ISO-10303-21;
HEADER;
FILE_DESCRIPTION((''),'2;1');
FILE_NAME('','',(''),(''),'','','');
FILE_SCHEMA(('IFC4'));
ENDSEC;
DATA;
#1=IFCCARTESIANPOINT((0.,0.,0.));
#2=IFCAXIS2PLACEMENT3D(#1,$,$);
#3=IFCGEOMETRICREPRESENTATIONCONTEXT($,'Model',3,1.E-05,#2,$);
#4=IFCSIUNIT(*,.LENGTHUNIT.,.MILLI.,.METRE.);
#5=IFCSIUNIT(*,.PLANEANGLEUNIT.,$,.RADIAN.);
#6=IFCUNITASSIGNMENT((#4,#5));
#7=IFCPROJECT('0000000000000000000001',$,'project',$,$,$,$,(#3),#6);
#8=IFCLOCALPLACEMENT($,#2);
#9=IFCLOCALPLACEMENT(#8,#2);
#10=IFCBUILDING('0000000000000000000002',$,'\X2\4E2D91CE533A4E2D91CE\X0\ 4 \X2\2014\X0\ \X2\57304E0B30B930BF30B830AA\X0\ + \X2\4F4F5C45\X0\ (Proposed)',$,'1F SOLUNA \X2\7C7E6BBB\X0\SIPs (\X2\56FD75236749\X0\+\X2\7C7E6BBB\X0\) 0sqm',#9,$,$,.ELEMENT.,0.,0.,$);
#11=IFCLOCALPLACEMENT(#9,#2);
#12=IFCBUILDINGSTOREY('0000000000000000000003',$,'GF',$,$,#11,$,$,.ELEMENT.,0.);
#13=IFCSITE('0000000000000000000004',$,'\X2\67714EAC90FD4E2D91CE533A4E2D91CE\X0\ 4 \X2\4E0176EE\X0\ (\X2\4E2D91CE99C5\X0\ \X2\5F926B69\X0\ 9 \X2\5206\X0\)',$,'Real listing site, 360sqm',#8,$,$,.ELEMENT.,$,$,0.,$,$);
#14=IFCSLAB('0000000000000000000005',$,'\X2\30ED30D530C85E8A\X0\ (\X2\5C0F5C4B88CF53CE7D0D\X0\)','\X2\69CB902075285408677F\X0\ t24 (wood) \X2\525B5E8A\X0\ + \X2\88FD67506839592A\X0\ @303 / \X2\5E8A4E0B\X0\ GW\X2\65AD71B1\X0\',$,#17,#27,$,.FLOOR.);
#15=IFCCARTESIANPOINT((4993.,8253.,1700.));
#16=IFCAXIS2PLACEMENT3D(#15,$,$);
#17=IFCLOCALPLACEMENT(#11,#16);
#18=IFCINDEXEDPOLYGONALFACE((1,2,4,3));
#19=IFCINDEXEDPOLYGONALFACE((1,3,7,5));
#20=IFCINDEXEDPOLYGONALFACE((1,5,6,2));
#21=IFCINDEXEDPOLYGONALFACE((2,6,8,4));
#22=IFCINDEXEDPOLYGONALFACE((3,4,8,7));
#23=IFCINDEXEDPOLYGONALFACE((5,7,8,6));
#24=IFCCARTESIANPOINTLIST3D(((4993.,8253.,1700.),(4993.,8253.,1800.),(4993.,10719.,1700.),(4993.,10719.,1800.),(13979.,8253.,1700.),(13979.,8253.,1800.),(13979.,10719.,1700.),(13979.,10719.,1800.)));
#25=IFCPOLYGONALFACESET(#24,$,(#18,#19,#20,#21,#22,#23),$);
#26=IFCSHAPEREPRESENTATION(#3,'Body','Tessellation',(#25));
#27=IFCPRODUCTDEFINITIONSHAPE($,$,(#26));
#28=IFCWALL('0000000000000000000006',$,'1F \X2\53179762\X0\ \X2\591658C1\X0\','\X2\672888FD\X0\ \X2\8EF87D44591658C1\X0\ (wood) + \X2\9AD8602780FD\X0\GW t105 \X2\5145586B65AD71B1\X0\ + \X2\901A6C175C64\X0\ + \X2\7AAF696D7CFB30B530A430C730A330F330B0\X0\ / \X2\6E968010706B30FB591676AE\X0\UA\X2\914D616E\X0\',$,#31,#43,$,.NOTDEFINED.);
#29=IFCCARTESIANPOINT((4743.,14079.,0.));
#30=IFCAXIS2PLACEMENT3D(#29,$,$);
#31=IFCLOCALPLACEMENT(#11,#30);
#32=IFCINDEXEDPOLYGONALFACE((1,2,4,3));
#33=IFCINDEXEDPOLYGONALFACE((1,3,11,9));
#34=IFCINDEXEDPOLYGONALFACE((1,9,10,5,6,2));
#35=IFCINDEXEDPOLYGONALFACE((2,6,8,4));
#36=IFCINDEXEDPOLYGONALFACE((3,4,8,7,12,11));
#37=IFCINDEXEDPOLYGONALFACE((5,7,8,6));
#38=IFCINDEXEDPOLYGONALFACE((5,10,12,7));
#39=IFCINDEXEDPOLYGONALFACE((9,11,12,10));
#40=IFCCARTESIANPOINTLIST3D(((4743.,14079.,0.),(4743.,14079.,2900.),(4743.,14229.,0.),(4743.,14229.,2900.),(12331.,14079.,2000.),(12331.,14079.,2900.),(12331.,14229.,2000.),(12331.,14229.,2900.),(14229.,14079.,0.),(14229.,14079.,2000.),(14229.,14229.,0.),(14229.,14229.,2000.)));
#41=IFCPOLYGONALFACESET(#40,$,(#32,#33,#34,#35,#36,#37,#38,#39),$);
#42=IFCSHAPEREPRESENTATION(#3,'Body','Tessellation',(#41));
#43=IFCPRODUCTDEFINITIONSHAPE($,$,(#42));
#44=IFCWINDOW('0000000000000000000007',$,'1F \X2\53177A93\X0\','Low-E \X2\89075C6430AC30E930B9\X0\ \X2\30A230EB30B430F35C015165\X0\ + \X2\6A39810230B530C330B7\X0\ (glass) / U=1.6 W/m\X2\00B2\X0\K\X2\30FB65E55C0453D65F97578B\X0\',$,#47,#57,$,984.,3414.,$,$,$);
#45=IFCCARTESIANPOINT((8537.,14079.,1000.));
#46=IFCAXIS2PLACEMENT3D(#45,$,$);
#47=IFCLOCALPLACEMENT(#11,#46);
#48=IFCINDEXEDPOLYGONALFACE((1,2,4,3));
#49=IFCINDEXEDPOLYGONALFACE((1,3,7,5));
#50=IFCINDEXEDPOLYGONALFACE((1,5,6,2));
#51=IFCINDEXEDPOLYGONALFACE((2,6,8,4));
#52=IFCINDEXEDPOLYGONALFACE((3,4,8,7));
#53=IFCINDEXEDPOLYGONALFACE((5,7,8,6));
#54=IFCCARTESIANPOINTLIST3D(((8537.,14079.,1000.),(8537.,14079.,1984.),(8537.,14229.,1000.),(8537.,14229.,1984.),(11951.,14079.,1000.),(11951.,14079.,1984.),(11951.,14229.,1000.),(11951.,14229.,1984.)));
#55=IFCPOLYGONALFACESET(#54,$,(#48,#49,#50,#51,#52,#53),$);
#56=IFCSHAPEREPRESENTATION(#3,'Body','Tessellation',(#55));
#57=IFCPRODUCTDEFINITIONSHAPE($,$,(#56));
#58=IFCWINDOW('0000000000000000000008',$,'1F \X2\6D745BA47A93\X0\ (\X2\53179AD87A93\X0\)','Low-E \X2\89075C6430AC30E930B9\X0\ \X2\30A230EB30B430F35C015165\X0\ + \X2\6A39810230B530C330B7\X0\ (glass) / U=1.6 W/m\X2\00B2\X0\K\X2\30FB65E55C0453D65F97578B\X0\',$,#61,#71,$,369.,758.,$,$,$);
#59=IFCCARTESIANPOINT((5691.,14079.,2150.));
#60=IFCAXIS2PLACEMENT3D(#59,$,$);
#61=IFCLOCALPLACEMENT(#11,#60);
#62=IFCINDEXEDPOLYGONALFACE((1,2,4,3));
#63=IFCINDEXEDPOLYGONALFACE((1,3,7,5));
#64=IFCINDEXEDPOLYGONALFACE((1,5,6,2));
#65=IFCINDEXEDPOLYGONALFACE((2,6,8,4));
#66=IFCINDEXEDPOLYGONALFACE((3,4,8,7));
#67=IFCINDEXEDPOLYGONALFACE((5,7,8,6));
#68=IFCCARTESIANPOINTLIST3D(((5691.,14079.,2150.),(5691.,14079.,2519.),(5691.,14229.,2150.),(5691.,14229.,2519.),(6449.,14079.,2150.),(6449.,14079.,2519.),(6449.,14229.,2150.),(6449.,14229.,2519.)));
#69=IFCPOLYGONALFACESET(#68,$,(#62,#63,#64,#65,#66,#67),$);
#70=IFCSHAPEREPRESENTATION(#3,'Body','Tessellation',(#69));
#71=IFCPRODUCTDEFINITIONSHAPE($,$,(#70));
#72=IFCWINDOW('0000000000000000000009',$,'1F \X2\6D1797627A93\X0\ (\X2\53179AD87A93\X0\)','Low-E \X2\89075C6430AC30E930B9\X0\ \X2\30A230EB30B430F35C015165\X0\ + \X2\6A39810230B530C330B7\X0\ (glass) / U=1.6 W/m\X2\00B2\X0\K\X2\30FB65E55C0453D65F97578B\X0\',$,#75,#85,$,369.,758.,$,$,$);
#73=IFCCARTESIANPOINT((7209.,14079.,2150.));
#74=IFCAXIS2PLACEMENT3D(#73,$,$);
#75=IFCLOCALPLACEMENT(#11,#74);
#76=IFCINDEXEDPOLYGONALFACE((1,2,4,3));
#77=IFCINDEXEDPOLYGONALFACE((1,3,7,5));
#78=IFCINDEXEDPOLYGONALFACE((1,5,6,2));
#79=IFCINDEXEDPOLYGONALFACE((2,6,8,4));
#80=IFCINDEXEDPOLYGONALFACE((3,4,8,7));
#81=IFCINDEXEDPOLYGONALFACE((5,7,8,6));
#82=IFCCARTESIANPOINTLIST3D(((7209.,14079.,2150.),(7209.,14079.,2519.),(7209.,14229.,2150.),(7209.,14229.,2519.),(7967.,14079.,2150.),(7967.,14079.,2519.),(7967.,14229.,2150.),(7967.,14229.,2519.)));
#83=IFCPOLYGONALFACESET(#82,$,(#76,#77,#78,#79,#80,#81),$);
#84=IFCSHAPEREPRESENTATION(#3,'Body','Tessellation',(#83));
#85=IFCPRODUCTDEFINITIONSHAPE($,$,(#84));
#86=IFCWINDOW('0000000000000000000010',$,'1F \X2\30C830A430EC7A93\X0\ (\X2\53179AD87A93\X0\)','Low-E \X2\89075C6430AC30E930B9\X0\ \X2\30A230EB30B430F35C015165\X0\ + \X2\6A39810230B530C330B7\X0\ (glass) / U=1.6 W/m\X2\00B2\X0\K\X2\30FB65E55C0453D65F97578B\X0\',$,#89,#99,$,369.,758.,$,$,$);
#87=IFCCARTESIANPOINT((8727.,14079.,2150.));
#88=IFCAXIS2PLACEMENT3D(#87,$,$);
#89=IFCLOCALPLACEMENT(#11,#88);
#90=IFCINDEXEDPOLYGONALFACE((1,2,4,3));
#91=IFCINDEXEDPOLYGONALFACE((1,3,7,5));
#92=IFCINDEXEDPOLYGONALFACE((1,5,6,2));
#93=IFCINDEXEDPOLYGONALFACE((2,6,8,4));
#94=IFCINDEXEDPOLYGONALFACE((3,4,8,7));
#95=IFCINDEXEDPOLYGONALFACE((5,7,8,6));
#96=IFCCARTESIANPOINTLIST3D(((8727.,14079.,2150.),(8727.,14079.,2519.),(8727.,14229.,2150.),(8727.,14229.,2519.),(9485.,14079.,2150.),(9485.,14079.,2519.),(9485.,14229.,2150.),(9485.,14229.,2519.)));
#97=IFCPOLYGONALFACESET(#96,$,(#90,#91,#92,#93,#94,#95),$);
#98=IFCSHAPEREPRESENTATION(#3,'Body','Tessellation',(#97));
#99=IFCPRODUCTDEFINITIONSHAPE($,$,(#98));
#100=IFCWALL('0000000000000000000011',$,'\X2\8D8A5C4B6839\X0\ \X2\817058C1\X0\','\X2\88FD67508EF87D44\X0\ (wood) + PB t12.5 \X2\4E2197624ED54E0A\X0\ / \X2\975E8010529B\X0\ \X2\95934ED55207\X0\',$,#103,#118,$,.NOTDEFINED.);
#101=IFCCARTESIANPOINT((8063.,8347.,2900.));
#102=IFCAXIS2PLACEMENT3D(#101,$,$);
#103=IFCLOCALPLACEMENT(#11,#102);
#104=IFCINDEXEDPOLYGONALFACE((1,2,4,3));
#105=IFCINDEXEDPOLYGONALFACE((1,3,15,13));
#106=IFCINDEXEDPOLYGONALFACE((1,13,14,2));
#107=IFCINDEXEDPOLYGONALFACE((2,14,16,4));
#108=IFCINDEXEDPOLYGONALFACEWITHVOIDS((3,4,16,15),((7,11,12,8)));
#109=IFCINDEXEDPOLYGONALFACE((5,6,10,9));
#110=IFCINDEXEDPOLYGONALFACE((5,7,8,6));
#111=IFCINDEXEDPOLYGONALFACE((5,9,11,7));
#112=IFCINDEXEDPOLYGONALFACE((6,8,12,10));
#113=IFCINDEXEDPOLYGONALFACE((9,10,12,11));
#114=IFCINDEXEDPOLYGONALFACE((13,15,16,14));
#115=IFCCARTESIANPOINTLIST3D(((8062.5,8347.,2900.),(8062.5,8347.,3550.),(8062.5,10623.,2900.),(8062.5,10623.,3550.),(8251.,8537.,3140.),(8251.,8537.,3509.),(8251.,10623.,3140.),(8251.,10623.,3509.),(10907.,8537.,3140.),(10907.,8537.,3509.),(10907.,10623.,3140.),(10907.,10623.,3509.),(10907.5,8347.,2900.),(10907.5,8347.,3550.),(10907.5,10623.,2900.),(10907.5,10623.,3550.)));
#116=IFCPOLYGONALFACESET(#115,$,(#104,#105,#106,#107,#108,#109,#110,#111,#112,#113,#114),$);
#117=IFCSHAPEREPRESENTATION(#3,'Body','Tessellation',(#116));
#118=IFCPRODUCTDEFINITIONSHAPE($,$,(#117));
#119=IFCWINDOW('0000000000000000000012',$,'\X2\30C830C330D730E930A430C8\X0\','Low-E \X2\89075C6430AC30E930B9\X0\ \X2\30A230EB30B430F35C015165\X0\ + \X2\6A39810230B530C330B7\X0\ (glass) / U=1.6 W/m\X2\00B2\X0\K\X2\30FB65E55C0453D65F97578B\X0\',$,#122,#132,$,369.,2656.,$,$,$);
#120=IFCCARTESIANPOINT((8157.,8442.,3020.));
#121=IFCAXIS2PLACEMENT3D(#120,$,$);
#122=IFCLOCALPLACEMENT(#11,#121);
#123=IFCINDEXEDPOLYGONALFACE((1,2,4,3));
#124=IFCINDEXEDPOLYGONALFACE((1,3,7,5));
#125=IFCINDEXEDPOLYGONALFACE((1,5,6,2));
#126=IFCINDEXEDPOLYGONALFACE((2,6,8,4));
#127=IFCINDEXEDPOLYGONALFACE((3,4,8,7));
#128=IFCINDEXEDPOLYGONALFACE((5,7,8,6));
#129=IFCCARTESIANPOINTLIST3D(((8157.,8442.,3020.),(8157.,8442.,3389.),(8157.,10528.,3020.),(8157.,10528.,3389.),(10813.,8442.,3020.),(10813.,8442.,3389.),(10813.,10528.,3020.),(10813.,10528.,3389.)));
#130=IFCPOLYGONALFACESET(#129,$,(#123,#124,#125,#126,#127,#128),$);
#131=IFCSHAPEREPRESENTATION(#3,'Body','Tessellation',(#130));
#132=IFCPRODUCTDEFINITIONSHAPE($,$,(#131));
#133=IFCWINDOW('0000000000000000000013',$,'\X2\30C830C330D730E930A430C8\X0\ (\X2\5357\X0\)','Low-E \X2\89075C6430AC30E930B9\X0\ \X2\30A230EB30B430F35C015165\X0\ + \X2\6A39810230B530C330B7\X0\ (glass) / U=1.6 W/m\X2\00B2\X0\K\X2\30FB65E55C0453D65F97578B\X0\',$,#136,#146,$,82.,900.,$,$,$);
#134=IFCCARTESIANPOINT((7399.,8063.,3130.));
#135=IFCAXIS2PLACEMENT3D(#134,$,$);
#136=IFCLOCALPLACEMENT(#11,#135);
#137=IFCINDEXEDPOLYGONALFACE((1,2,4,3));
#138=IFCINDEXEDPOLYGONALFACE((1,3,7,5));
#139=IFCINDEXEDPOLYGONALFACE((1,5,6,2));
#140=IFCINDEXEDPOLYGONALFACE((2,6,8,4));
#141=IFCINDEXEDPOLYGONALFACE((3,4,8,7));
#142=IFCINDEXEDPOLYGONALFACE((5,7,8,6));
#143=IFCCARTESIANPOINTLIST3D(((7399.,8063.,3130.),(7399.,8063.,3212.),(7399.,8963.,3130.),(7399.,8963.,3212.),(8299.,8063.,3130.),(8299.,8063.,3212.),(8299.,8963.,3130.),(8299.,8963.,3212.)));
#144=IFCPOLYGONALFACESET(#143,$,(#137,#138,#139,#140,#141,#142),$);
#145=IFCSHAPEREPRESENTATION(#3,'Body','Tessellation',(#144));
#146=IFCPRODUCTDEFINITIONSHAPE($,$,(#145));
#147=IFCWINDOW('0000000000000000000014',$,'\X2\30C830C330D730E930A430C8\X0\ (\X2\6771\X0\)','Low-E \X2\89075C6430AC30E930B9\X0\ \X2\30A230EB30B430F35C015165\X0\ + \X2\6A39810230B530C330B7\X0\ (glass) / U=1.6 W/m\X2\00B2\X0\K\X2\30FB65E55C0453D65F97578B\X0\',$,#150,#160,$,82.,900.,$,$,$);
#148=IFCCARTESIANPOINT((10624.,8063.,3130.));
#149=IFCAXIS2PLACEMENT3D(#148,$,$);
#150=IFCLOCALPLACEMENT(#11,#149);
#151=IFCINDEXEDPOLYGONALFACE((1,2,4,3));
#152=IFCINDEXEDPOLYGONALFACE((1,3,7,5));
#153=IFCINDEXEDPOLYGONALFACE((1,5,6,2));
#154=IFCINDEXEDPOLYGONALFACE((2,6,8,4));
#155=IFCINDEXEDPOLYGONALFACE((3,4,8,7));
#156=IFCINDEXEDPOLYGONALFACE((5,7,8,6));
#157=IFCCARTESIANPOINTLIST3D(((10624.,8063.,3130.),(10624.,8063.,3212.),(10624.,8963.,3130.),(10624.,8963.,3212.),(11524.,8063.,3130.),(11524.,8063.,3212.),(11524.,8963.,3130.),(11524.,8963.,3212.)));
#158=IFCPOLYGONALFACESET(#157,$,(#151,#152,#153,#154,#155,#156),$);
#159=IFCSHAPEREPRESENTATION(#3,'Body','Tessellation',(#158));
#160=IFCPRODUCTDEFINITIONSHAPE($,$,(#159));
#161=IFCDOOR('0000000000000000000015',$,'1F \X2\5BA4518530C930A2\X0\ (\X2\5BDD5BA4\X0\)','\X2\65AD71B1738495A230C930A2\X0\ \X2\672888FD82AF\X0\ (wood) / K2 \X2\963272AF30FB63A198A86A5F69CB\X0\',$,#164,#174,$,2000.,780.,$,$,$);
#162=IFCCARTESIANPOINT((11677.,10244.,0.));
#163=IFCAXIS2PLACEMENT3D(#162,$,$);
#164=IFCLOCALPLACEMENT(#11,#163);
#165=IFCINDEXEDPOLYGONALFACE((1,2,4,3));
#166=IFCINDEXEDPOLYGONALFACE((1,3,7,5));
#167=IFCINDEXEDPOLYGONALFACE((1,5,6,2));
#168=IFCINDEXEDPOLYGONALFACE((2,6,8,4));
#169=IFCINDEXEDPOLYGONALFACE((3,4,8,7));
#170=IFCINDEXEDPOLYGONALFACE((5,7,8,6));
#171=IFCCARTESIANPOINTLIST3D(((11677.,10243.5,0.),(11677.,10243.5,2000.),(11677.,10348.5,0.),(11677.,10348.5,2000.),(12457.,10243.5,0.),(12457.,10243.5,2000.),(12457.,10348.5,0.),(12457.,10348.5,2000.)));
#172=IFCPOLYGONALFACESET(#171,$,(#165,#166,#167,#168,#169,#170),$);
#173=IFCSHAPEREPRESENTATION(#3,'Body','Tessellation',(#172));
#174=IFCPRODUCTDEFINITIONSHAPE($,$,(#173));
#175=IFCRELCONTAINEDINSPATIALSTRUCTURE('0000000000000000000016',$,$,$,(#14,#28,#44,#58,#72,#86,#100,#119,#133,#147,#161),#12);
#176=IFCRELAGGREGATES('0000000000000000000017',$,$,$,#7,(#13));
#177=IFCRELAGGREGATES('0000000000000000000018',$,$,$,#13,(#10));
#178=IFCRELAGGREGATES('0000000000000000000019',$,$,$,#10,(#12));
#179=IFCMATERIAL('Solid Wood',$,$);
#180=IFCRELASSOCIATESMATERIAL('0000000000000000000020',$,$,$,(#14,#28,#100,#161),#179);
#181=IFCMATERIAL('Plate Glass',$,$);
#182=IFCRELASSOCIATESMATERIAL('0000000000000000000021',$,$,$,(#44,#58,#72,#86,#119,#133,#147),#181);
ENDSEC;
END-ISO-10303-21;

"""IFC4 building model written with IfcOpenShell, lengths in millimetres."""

from ifc_helpers import new_model, si_unit, frame, frame_2d, origin, place, context, project, spatial, rectangle, extrude, material, element, fill, save


model = new_model("IFC4")

# Units and contexts
model_context = context("Model", 3, precision=1e-05, world=origin())
ifc_project = project(units=[si_unit("LENGTHUNIT", "METRE", prefix="MILLI"), si_unit("PLANEANGLEUNIT", "RADIAN")], contexts=[model_context])

# Site, building, storey
site_placement = place(None, origin())
site = spatial("IfcSite", under=ifc_project, at=site_placement, Name="東京都中野区中野 4 丁目 (中野駅 徒歩 9 分)", ObjectType="Real listing site, 360sqm", CompositionType="ELEMENT", RefElevation=0.0)
building_placement = place(site_placement, origin())
building = spatial("IfcBuilding", under=site, at=building_placement, Name="中野区中野 4 — 地下スタジオ + 住居 (Proposed)", ObjectType="1F SOLUNA 籾殻SIPs (国産杉+籾殻) 0sqm", CompositionType="ELEMENT", ElevationOfRefHeight=0.0, ElevationOfTerrain=0.0)
storey_placement = place(building_placement, origin())
storey = spatial("IfcBuildingStorey", under=building, at=storey_placement, Name="GF", CompositionType="ELEMENT", Elevation=0.0)

# Slab
ifc_material_1 = material(Name="Solid Wood")
slab_placement = place(storey_placement, frame((4993.0, 8253.0, 1700.0)))
element("IfcSlab", 1, at=slab_placement, inside=storey, material=ifc_material_1, Name="ロフト床 (小屋裏収納)", Description="構造用合板 t24 (wood) 剛床 + 製材根太 @303 / 床下 GW断熱", PredefinedType="FLOOR", context=model_context, shape_type="SweptSolid", body=[
    extrude(rectangle(XDim=8986.0, YDim=2466.0, at=frame_2d((4493.0, 1233.0))), frame((4993.0, 8253.0, 1700.0)), (0.0, 0.0, 1.0), 100.0),
])

# Wall, openings, windows
wall_1_placement = place(storey_placement, frame((4743.0, 14079.0, 0.0)))
wall_1 = element("IfcWall", 2, at=wall_1_placement, inside=storey, material=ifc_material_1, Name="1F 北面 外壁", Description="木製 軸組外壁 (wood) + 高性能GW t105 充填断熱 + 通気層 + 窯業系サイディング / 準耐火・外皮UA配慮", PredefinedType="NOTDEFINED", context=model_context, shape_type="SweptSolid", body=[
    extrude(rectangle(XDim=9486.0, YDim=150.0, at=frame_2d((4743.0, 75.0))), frame((4743.0, 14079.0, 0.0)), (0.0, 0.0, 1.0), 2900.0),
])
opening_1_placement = place(storey_placement, frame((8537.0, 14079.0, 1000.0)))
opening_1 = element("IfcOpeningElement", 3, at=opening_1_placement, cuts=wall_1, PredefinedType="NOTDEFINED", context=model_context, shape_type="SweptSolid", body=[
    extrude(rectangle(XDim=3414.0, YDim=150.0, at=frame_2d((1707.0, 75.0))), frame((8537.0, 14079.0, 1000.0)), (0.0, 0.0, 1.0), 984.0),
])
opening_2_placement = place(storey_placement, frame((5691.0, 14079.0, 2150.0)))
opening_2 = element("IfcOpeningElement", 4, at=opening_2_placement, cuts=wall_1, PredefinedType="NOTDEFINED", context=model_context, shape_type="SweptSolid", body=[
    extrude(rectangle(XDim=758.0, YDim=150.0, at=frame_2d((379.0, 75.0))), frame((5691.0, 14079.0, 2150.0)), (0.0, 0.0, 1.0), 369.0),
])
opening_3_placement = place(storey_placement, frame((7209.0, 14079.0, 2150.0)))
opening_3 = element("IfcOpeningElement", 5, at=opening_3_placement, cuts=wall_1, PredefinedType="NOTDEFINED", context=model_context, shape_type="SweptSolid", body=[
    extrude(rectangle(XDim=758.0, YDim=150.0, at=frame_2d((379.0, 75.0))), frame((7209.0, 14079.0, 2150.0)), (0.0, 0.0, 1.0), 369.0),
])
opening_4_placement = place(storey_placement, frame((8727.0, 14079.0, 2150.0)))
opening_4 = element("IfcOpeningElement", 6, at=opening_4_placement, cuts=wall_1, PredefinedType="NOTDEFINED", context=model_context, shape_type="SweptSolid", body=[
    extrude(rectangle(XDim=758.0, YDim=150.0, at=frame_2d((379.0, 75.0))), frame((8727.0, 14079.0, 2150.0)), (0.0, 0.0, 1.0), 369.0),
])
ifc_material_2 = material(Name="Plate Glass")
window_1_placement = place(storey_placement, frame((8537.0, 14079.0, 1000.0)))
window_1 = element("IfcWindow", 7, at=window_1_placement, inside=storey, material=ifc_material_2, Name="1F 北窓", Description="Low-E 複層ガラス アルゴン封入 + 樹脂サッシ (glass) / U=1.6 W/m²K・日射取得型", OverallHeight=984.0, OverallWidth=3414.0, context=model_context, shape_type="SweptSolid", body=[
    extrude(rectangle(XDim=3414.0, YDim=150.0, at=frame_2d((1707.0, 75.0))), frame((8537.0, 14079.0, 1000.0)), (0.0, 0.0, 1.0), 984.0),
])
fill(opening_1, window_1)
window_2_placement = place(storey_placement, frame((5691.0, 14079.0, 2150.0)))
window_2 = element("IfcWindow", 8, at=window_2_placement, inside=storey, material=ifc_material_2, Name="1F 浴室窓 (北高窓)", Description="Low-E 複層ガラス アルゴン封入 + 樹脂サッシ (glass) / U=1.6 W/m²K・日射取得型", OverallHeight=369.0, OverallWidth=758.0, context=model_context, shape_type="SweptSolid", body=[
    extrude(rectangle(XDim=758.0, YDim=150.0, at=frame_2d((379.0, 75.0))), frame((5691.0, 14079.0, 2150.0)), (0.0, 0.0, 1.0), 369.0),
])
fill(opening_2, window_2)
window_3_placement = place(storey_placement, frame((7209.0, 14079.0, 2150.0)))
window_3 = element("IfcWindow", 9, at=window_3_placement, inside=storey, material=ifc_material_2, Name="1F 洗面窓 (北高窓)", Description="Low-E 複層ガラス アルゴン封入 + 樹脂サッシ (glass) / U=1.6 W/m²K・日射取得型", OverallHeight=369.0, OverallWidth=758.0, context=model_context, shape_type="SweptSolid", body=[
    extrude(rectangle(XDim=758.0, YDim=150.0, at=frame_2d((379.0, 75.0))), frame((7209.0, 14079.0, 2150.0)), (0.0, 0.0, 1.0), 369.0),
])
fill(opening_3, window_3)
window_4_placement = place(storey_placement, frame((8727.0, 14079.0, 2150.0)))
window_4 = element("IfcWindow", 10, at=window_4_placement, inside=storey, material=ifc_material_2, Name="1F トイレ窓 (北高窓)", Description="Low-E 複層ガラス アルゴン封入 + 樹脂サッシ (glass) / U=1.6 W/m²K・日射取得型", OverallHeight=369.0, OverallWidth=758.0, context=model_context, shape_type="SweptSolid", body=[
    extrude(rectangle(XDim=758.0, YDim=150.0, at=frame_2d((379.0, 75.0))), frame((8727.0, 14079.0, 2150.0)), (0.0, 0.0, 1.0), 369.0),
])
fill(opening_4, window_4)

# Wall, openings, windows
wall_2_placement = place(storey_placement, frame((8063.0, 8347.0, 2900.0)))
wall_2 = element("IfcWall", 11, at=wall_2_placement, inside=storey, material=ifc_material_1, Name="越屋根 腰壁", Description="製材軸組 (wood) + PB t12.5 両面仕上 / 非耐力 間仕切", PredefinedType="NOTDEFINED", context=model_context, shape_type="SweptSolid", body=[
    extrude(rectangle(XDim=2845.0, YDim=2276.0, at=frame_2d((1422.0, 1138.0))), frame((8063.0, 8347.0, 2900.0)), (0.0, 0.0, 1.0), 650.0),
])
opening_5_placement = place(storey_placement, frame((8157.0, 8442.0, 3020.0)))
opening_5 = element("IfcOpeningElement", 12, at=opening_5_placement, cuts=wall_2, PredefinedType="NOTDEFINED", context=model_context, shape_type="SweptSolid", body=[
    extrude(rectangle(XDim=2656.0, YDim=2086.0, at=frame_2d((1328.0, 1043.0))), frame((8157.0, 8442.0, 3020.0)), (0.0, 0.0, 1.0), 369.0),
])
opening_6_placement = place(storey_placement, frame((7399.0, 8063.0, 3130.0)))
opening_6 = element("IfcOpeningElement", 13, at=opening_6_placement, cuts=wall_2, PredefinedType="NOTDEFINED", context=model_context, shape_type="SweptSolid", body=[
    extrude(rectangle(XDim=900.0, YDim=900.0, at=frame_2d((450.0, 450.0))), frame((7399.0, 8063.0, 3130.0)), (0.0, 0.0, 1.0), 82.0),
])
opening_7_placement = place(storey_placement, frame((10624.0, 8063.0, 3130.0)))
opening_7 = element("IfcOpeningElement", 14, at=opening_7_placement, cuts=wall_2, PredefinedType="NOTDEFINED", context=model_context, shape_type="SweptSolid", body=[
    extrude(rectangle(XDim=900.0, YDim=900.0, at=frame_2d((450.0, 450.0))), frame((10624.0, 8063.0, 3130.0)), (0.0, 0.0, 1.0), 82.0),
])
window_5_placement = place(storey_placement, frame((8157.0, 8442.0, 3020.0)))
window_5 = element("IfcWindow", 15, at=window_5_placement, inside=storey, material=ifc_material_2, Name="トップライト", Description="Low-E 複層ガラス アルゴン封入 + 樹脂サッシ (glass) / U=1.6 W/m²K・日射取得型", OverallHeight=369.0, OverallWidth=2656.0, context=model_context, shape_type="SweptSolid", body=[
    extrude(rectangle(XDim=2656.0, YDim=2086.0, at=frame_2d((1328.0, 1043.0))), frame((8157.0, 8442.0, 3020.0)), (0.0, 0.0, 1.0), 369.0),
])
fill(opening_5, window_5)
window_6_placement = place(storey_placement, frame((7399.0, 8063.0, 3130.0)))
window_6 = element("IfcWindow", 16, at=window_6_placement, inside=storey, material=ifc_material_2, Name="トップライト (南)", Description="Low-E 複層ガラス アルゴン封入 + 樹脂サッシ (glass) / U=1.6 W/m²K・日射取得型", OverallHeight=82.0, OverallWidth=900.0, context=model_context, shape_type="SweptSolid", body=[
    extrude(rectangle(XDim=900.0, YDim=900.0, at=frame_2d((450.0, 450.0))), frame((7399.0, 8063.0, 3130.0)), (0.0, 0.0, 1.0), 82.0),
])
fill(opening_6, window_6)
window_7_placement = place(storey_placement, frame((10624.0, 8063.0, 3130.0)))
window_7 = element("IfcWindow", 17, at=window_7_placement, inside=storey, material=ifc_material_2, Name="トップライト (東)", Description="Low-E 複層ガラス アルゴン封入 + 樹脂サッシ (glass) / U=1.6 W/m²K・日射取得型", OverallHeight=82.0, OverallWidth=900.0, context=model_context, shape_type="SweptSolid", body=[
    extrude(rectangle(XDim=900.0, YDim=900.0, at=frame_2d((450.0, 450.0))), frame((10624.0, 8063.0, 3130.0)), (0.0, 0.0, 1.0), 82.0),
])
fill(opening_7, window_7)

# Door
door_1_placement = place(storey_placement, frame((11677.0, 10244.0, 0.0)))
element("IfcDoor", 18, at=door_1_placement, inside=storey, material=ifc_material_1, Name="1F 室内ドア (寝室)", Description="断熱玄関ドア 木製芯 (wood) / K2 防犯・採風機構", OverallHeight=2000.0, OverallWidth=780.0, context=model_context, shape_type="SweptSolid", body=[
    extrude(rectangle(XDim=780.0, YDim=105.0, at=frame_2d((390.0, 52.0))), frame((11677.0, 10244.0, 0.0)), (0.0, 0.0, 1.0), 2000.0),
])

save(model, "model.ifc")
